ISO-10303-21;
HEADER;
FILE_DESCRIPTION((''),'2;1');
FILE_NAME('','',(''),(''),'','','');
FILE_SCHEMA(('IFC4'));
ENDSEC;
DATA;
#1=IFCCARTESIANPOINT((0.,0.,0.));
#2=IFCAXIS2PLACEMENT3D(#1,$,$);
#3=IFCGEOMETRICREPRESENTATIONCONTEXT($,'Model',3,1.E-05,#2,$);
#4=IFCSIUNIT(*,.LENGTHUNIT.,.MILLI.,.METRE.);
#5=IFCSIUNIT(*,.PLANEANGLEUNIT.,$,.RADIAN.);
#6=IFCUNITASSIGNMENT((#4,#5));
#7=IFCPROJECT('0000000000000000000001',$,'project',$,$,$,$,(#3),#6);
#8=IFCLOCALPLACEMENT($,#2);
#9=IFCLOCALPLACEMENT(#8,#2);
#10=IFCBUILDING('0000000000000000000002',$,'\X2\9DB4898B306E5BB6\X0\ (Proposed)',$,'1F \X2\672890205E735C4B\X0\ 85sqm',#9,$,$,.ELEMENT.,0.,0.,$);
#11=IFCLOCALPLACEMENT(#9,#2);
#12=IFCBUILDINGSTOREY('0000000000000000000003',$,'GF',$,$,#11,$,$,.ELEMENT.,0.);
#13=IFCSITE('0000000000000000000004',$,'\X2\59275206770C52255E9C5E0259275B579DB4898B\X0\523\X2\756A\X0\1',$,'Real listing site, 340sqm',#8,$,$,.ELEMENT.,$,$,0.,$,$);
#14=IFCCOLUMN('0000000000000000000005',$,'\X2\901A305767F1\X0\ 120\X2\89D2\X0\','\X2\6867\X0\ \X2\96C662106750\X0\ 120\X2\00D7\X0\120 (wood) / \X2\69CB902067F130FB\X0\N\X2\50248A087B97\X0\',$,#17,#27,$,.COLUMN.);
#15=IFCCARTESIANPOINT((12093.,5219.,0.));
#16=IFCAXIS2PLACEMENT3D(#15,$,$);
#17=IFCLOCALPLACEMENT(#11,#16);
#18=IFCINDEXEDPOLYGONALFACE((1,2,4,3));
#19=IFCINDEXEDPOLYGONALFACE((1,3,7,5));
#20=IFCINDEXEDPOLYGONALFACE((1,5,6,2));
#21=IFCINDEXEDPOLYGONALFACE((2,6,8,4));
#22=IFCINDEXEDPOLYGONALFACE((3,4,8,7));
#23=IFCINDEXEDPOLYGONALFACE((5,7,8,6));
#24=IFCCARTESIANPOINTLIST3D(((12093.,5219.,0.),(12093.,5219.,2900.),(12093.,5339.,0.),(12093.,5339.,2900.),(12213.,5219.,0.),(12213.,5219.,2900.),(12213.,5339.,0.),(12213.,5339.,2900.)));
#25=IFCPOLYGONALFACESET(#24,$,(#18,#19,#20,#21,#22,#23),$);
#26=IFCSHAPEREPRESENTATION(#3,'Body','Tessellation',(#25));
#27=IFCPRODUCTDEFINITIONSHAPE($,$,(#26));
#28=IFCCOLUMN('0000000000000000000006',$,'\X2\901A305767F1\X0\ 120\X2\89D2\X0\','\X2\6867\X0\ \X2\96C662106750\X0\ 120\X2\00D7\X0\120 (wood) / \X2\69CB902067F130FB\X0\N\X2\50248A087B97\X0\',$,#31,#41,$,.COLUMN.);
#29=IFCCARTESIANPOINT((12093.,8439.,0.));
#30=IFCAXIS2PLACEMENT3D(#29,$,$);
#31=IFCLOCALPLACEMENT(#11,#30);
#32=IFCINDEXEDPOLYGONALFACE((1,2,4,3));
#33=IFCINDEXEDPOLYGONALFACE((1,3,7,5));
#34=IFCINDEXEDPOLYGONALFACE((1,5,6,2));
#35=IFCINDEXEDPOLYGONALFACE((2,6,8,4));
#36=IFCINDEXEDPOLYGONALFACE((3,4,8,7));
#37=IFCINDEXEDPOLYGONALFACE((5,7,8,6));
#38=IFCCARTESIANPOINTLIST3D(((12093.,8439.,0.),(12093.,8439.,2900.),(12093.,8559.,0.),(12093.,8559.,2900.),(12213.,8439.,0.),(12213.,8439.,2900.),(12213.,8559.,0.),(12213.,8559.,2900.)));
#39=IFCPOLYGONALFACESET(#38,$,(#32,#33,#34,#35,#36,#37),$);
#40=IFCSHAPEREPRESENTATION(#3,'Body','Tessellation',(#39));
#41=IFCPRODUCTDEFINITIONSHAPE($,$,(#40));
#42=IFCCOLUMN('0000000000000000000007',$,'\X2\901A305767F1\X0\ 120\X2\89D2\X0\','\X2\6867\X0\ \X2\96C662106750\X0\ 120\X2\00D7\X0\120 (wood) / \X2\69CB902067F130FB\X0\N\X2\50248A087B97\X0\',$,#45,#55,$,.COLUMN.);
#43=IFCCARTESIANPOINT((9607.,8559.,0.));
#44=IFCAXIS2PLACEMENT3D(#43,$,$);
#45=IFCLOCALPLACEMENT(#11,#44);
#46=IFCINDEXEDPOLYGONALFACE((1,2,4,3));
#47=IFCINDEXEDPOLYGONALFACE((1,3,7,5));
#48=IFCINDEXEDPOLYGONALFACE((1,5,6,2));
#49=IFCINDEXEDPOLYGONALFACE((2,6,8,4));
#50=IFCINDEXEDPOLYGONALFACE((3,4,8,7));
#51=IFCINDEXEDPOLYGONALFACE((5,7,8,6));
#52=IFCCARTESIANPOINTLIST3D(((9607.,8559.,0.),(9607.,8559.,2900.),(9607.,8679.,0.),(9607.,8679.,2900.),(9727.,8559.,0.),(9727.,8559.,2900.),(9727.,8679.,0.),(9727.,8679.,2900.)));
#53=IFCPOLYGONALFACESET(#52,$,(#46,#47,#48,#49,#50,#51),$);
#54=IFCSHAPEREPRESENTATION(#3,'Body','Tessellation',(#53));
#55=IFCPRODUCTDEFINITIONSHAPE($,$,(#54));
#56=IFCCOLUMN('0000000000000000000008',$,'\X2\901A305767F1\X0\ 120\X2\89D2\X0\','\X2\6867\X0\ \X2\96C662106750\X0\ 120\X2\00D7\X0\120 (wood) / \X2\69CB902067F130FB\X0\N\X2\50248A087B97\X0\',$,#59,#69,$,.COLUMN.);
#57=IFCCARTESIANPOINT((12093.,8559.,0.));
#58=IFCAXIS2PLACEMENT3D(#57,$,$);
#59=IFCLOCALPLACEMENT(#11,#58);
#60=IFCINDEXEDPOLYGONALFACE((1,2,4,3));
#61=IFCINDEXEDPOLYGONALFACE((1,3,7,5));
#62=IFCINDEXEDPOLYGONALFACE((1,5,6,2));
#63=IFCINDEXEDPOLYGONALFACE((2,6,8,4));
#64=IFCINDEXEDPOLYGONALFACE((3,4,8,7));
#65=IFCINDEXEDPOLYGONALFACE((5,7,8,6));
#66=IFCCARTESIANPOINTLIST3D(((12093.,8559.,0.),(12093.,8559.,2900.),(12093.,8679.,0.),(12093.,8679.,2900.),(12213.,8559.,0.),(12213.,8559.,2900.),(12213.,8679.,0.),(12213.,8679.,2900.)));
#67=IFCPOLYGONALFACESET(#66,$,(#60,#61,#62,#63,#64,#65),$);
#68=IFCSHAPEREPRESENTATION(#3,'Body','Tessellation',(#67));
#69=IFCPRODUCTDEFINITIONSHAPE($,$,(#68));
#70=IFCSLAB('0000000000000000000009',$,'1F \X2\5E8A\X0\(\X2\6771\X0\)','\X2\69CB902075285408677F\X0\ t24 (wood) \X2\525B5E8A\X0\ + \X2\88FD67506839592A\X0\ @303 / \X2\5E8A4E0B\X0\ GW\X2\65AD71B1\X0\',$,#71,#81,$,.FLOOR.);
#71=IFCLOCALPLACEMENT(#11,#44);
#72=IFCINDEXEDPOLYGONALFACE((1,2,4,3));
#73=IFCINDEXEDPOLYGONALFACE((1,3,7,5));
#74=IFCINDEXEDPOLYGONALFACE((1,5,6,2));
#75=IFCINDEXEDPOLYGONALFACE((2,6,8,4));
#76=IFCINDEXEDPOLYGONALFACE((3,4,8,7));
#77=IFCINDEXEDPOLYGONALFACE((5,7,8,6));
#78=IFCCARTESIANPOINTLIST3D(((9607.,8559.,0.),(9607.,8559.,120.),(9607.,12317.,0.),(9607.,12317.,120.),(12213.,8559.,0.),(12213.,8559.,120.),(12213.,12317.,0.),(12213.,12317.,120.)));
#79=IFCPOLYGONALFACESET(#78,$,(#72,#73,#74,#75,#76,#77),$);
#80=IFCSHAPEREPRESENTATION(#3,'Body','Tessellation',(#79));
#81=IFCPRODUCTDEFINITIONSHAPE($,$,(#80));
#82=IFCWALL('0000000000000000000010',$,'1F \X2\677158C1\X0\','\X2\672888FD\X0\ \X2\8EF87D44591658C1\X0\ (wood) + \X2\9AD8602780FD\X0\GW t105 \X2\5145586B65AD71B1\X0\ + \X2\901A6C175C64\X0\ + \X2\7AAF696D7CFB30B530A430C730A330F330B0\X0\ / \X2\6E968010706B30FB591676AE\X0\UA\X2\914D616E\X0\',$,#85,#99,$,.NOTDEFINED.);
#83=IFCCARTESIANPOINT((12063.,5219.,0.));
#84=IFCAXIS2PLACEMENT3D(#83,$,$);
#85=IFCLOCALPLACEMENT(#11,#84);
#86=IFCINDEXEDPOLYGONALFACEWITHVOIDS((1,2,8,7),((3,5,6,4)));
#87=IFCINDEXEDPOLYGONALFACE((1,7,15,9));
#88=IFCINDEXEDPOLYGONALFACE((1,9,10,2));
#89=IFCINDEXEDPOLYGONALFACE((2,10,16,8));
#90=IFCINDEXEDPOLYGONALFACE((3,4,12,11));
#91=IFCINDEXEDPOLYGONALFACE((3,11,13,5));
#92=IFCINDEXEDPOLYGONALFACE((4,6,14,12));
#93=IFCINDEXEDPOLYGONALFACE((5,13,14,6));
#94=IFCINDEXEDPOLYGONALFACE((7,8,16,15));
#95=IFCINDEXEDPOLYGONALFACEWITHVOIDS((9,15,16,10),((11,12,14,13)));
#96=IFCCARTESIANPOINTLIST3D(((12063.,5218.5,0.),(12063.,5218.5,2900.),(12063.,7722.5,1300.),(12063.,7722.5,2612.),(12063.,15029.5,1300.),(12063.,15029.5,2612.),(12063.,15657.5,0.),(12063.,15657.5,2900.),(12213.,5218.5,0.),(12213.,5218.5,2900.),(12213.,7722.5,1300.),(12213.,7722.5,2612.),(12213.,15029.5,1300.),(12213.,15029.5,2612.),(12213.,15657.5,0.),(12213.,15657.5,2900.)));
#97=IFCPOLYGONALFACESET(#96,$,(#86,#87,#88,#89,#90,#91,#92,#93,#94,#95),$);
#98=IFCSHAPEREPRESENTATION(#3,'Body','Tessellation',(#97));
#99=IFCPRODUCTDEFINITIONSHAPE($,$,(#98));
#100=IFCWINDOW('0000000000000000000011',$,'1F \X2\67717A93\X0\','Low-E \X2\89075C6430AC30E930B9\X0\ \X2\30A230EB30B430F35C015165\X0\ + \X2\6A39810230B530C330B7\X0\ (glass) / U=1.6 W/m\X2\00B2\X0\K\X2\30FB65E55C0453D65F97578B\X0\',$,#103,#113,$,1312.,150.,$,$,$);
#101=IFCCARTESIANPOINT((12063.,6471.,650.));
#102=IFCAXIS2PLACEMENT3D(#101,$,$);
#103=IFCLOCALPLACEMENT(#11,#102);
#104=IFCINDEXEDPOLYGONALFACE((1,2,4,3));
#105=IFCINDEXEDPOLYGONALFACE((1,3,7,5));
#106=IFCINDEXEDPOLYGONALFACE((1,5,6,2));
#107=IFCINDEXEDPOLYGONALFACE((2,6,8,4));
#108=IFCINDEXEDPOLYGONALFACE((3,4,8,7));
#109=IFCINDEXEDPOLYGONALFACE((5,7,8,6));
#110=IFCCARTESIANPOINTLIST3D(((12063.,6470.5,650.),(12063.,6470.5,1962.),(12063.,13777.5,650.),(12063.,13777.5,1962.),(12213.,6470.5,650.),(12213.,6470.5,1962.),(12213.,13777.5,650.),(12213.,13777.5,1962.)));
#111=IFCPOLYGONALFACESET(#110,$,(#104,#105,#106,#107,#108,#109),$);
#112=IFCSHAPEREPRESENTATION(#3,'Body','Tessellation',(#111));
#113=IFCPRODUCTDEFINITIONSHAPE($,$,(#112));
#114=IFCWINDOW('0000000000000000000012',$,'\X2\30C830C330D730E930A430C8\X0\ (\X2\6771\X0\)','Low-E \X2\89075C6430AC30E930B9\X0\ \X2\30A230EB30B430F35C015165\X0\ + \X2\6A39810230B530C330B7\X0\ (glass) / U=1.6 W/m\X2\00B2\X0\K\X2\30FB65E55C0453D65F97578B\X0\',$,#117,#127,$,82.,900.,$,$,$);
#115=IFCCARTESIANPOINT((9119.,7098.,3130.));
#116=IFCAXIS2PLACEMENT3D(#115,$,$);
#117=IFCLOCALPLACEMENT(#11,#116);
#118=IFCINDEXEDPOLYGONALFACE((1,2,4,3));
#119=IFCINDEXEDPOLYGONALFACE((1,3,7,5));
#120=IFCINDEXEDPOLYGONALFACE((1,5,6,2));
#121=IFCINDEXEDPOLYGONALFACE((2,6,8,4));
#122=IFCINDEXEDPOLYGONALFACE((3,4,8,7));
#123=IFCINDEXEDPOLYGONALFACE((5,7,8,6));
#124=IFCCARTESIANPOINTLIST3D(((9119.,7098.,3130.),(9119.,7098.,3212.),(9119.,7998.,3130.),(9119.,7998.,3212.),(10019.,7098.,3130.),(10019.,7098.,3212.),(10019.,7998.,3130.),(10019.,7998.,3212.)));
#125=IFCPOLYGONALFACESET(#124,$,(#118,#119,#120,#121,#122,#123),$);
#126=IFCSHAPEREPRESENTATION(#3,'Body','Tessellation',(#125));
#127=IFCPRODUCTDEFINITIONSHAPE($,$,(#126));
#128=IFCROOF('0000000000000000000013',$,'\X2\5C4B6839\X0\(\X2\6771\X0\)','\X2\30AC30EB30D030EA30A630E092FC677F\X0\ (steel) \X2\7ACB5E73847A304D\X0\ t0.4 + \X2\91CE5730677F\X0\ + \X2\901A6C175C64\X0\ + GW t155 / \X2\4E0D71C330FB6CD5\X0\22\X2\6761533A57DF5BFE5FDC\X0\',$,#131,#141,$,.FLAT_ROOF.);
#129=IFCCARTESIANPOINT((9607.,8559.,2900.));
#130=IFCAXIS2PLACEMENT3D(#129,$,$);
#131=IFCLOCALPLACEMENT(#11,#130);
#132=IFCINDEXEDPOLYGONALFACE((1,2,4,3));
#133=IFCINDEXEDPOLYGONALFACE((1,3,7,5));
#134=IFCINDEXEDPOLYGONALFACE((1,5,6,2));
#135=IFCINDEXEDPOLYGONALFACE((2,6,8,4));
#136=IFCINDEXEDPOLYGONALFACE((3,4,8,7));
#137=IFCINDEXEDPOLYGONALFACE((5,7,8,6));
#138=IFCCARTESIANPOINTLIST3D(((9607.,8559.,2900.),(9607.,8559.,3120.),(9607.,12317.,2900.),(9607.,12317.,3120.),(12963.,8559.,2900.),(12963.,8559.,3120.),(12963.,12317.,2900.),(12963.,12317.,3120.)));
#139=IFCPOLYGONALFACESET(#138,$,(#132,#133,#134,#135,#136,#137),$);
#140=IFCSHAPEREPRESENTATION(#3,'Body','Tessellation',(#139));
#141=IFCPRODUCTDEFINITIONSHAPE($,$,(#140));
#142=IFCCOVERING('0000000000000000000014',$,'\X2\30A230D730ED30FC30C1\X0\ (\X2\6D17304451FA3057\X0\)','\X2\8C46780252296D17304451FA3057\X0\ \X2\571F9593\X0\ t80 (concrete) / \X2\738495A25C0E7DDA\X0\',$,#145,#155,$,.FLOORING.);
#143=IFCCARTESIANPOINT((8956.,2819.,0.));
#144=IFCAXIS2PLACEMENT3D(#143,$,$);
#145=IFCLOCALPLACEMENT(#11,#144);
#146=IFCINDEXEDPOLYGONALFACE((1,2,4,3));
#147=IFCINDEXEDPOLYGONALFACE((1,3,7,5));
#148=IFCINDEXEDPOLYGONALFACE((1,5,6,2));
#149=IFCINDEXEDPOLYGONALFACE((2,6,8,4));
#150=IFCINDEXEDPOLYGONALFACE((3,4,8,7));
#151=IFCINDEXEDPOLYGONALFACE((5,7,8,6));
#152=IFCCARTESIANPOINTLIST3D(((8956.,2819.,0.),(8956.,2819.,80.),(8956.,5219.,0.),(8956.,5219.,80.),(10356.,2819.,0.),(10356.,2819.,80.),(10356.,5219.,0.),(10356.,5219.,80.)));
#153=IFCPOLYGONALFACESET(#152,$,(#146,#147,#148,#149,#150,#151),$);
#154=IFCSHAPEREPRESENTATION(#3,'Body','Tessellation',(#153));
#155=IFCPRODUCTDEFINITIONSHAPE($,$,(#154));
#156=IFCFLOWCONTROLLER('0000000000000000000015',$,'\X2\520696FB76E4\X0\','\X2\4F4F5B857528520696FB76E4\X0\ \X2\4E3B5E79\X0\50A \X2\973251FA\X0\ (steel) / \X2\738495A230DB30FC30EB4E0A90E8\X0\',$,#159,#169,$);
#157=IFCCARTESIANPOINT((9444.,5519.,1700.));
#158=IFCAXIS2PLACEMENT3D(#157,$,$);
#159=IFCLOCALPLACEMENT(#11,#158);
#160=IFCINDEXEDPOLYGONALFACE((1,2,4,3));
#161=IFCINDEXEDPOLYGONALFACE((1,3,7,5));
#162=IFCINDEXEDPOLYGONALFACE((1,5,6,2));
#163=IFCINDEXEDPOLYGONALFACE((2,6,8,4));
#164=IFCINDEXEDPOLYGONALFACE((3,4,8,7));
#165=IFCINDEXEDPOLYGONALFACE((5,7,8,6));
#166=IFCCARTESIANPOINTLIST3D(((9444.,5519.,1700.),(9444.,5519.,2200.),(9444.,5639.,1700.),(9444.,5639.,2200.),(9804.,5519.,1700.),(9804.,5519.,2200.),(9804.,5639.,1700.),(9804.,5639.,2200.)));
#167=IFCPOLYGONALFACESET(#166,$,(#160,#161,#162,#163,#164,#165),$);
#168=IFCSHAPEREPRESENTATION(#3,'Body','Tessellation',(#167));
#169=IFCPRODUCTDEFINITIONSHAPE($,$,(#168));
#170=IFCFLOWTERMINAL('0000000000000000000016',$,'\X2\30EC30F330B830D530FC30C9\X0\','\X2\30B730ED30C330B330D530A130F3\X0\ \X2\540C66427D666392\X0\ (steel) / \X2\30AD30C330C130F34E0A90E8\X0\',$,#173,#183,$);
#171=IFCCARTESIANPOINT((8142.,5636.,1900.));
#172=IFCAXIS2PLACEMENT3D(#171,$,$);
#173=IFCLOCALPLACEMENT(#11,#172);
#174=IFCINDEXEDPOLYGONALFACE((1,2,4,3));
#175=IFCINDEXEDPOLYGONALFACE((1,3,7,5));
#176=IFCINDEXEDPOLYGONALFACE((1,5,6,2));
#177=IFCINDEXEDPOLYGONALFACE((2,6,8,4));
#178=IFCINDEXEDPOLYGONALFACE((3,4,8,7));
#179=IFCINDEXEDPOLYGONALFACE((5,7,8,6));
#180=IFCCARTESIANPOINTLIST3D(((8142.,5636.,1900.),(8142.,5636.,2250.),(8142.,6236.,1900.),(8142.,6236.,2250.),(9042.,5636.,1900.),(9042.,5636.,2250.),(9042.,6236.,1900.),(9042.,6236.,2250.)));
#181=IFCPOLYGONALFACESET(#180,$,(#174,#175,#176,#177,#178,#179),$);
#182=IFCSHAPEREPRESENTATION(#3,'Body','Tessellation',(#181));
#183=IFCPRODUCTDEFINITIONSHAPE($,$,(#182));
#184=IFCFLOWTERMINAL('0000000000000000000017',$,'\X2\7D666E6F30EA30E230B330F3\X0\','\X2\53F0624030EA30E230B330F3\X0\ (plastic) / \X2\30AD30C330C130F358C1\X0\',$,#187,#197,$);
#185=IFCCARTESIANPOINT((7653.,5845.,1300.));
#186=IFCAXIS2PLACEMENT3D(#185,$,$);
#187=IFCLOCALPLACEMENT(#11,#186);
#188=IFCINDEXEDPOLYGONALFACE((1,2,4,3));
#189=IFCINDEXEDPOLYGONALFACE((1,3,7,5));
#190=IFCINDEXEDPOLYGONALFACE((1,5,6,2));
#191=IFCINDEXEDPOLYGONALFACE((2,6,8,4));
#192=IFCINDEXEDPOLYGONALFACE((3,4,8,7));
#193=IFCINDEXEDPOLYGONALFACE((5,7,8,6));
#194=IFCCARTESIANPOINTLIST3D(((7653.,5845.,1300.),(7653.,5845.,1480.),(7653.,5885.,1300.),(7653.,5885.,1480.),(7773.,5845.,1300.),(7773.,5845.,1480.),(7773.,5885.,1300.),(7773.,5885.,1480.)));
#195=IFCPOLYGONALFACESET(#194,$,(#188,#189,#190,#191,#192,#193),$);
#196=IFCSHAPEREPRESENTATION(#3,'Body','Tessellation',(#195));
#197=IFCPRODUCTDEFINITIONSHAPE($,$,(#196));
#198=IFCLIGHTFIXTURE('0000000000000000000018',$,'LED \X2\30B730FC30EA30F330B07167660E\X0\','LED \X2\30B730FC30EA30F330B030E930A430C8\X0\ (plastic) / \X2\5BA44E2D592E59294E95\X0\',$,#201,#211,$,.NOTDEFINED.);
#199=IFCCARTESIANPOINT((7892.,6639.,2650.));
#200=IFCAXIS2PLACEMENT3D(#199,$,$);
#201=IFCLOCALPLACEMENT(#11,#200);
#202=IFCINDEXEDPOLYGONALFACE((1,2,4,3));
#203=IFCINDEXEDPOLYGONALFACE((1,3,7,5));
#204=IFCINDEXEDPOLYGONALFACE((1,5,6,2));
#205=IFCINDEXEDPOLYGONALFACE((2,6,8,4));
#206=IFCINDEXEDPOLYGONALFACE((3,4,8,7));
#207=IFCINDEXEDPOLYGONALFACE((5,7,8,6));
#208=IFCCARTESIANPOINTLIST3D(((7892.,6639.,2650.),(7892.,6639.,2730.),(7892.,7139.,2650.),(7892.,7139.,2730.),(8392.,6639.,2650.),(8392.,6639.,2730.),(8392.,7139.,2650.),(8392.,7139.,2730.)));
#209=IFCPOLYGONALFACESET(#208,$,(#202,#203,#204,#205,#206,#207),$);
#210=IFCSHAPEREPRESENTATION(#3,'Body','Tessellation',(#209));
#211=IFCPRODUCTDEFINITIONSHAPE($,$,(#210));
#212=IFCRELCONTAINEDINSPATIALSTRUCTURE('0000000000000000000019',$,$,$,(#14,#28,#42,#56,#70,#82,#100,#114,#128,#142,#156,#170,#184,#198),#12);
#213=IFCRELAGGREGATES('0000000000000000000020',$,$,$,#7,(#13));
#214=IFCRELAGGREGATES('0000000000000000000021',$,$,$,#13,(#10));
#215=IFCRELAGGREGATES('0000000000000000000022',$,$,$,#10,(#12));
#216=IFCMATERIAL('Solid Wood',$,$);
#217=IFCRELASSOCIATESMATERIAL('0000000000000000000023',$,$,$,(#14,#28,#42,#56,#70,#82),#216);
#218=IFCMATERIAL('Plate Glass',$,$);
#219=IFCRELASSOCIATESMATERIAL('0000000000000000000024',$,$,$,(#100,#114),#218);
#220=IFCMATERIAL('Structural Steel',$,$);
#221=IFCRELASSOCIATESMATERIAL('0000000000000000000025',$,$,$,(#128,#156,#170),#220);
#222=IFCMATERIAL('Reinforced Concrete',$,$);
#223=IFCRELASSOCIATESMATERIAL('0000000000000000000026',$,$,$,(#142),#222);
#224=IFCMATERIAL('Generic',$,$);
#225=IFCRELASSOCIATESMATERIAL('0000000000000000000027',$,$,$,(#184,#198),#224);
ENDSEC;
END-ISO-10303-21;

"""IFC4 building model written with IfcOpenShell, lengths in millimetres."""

from ifc_helpers import new_model, si_unit, frame, frame_2d, origin, place, context, project, spatial, rectangle, extrude, material, element, fill, save


model = new_model("IFC4")

# Units and contexts
model_context = context("Model", 3, precision=1e-05, world=origin())
ifc_project = project(units=[si_unit("LENGTHUNIT", "METRE", prefix="MILLI"), si_unit("PLANEANGLEUNIT", "RADIAN")], contexts=[model_context])

# Site, building, storey
site_placement = place(None, origin())
site = spatial("IfcSite", under=ifc_project, at=site_placement, Name="大分県別府市大字鶴見523番1", ObjectType="Real listing site, 340sqm", CompositionType="ELEMENT", RefElevation=0.0)
building_placement = place(site_placement, origin())
building = spatial("IfcBuilding", under=site, at=building_placement, Name="鶴見の家 (Proposed)", ObjectType="1F 木造平屋 85sqm", CompositionType="ELEMENT", ElevationOfRefHeight=0.0, ElevationOfTerrain=0.0)
storey_placement = place(building_placement, origin())
storey = spatial("IfcBuildingStorey", under=building, at=storey_placement, Name="GF", CompositionType="ELEMENT", Elevation=0.0)

# Columns
ifc_material_1 = material(Name="Solid Wood")
column_1_placement = place(storey_placement, frame((12093.0, 5219.0, 0.0)))
element("IfcColumn", 1, at=column_1_placement, inside=storey, material=ifc_material_1, Name="通し柱 120角", Description="桧 集成材 120×120 (wood) / 構造柱・N値計算", PredefinedType="COLUMN", context=model_context, shape_type="SweptSolid", body=[
    extrude(rectangle(XDim=120.0, YDim=120.0, at=frame_2d((60.0, 60.0))), frame((12093.0, 5219.0, 0.0)), (0.0, 0.0, 1.0), 2900.0),
])
column_2_placement = place(storey_placement, frame((12093.0, 8439.0, 0.0)))
element("IfcColumn", 2, at=column_2_placement, inside=storey, material=ifc_material_1, Name="通し柱 120角", Description="桧 集成材 120×120 (wood) / 構造柱・N値計算", PredefinedType="COLUMN", context=model_context, shape_type="SweptSolid", body=[
    extrude(rectangle(XDim=120.0, YDim=120.0, at=frame_2d((60.0, 60.0))), frame((12093.0, 8439.0, 0.0)), (0.0, 0.0, 1.0), 2900.0),
])
column_3_placement = place(storey_placement, frame((9607.0, 8559.0, 0.0)))
element("IfcColumn", 3, at=column_3_placement, inside=storey, material=ifc_material_1, Name="通し柱 120角", Description="桧 集成材 120×120 (wood) / 構造柱・N値計算", PredefinedType="COLUMN", context=model_context, shape_type="SweptSolid", body=[
    extrude(rectangle(XDim=120.0, YDim=120.0, at=frame_2d((60.0, 60.0))), frame((9607.0, 8559.0, 0.0)), (0.0, 0.0, 1.0), 2900.0),
])
column_4_placement = place(storey_placement, frame((12093.0, 8559.0, 0.0)))
element("IfcColumn", 4, at=column_4_placement, inside=storey, material=ifc_material_1, Name="通し柱 120角", Description="桧 集成材 120×120 (wood) / 構造柱・N値計算", PredefinedType="COLUMN", context=model_context, shape_type="SweptSolid", body=[
    extrude(rectangle(XDim=120.0, YDim=120.0, at=frame_2d((60.0, 60.0))), frame((12093.0, 8559.0, 0.0)), (0.0, 0.0, 1.0), 2900.0),
])

# Slab
slab_placement = place(storey_placement, frame((9607.0, 8559.0, 0.0)))
element("IfcSlab", 5, at=slab_placement, inside=storey, material=ifc_material_1, Name="1F 床(東)", Description="構造用合板 t24 (wood) 剛床 + 製材根太 @303 / 床下 GW断熱", PredefinedType="FLOOR", context=model_context, shape_type="SweptSolid", body=[
    extrude(rectangle(XDim=2606.0, YDim=3758.0, at=frame_2d((1303.0, 1879.0))), frame((9607.0, 8559.0, 0.0)), (0.0, 0.0, 1.0), 120.0),
])

# Wall, opening, window
wall_1_placement = place(storey_placement, frame((12063.0, 5219.0, 0.0)))
wall_1 = element("IfcWall", 6, at=wall_1_placement, inside=storey, material=ifc_material_1, Name="1F 東壁", Description="木製 軸組外壁 (wood) + 高性能GW t105 充填断熱 + 通気層 + 窯業系サイディング / 準耐火・外皮UA配慮", PredefinedType="NOTDEFINED", context=model_context, shape_type="SweptSolid", body=[
    extrude(rectangle(XDim=150.0, YDim=10439.0, at=frame_2d((75.0, 5219.0))), frame((12063.0, 5219.0, 0.0)), (0.0, 0.0, 1.0), 2900.0),
])
opening_placement = place(storey_placement, frame((12063.0, 6471.0, 650.0)))
opening = element("IfcOpeningElement", 7, at=opening_placement, cuts=wall_1, PredefinedType="NOTDEFINED", context=model_context, shape_type="SweptSolid", body=[
    extrude(rectangle(XDim=150.0, YDim=7307.0, at=frame_2d((75.0, 3653.0))), frame((12063.0, 6471.0, 650.0)), (0.0, 0.0, 1.0), 1312.0),
])
ifc_material_2 = material(Name="Plate Glass")
window_1_placement = place(storey_placement, frame((12063.0, 6471.0, 650.0)))
window_1 = element("IfcWindow", 8, at=window_1_placement, inside=storey, material=ifc_material_2, Name="1F 東窓", Description="Low-E 複層ガラス アルゴン封入 + 樹脂サッシ (glass) / U=1.6 W/m²K・日射取得型", OverallHeight=1312.0, OverallWidth=150.0, context=model_context, shape_type="SweptSolid", body=[
    extrude(rectangle(XDim=150.0, YDim=7307.0, at=frame_2d((75.0, 3653.0))), frame((12063.0, 6471.0, 650.0)), (0.0, 0.0, 1.0), 1312.0),
])
fill(opening, window_1)

# Window
window_2_placement = place(storey_placement, frame((9119.0, 7098.0, 3130.0)))
element("IfcWindow", 9, at=window_2_placement, inside=storey, material=ifc_material_2, Name="トップライト (東)", Description="Low-E 複層ガラス アルゴン封入 + 樹脂サッシ (glass) / U=1.6 W/m²K・日射取得型", OverallHeight=82.0, OverallWidth=900.0, context=model_context, shape_type="SweptSolid", body=[
    extrude(rectangle(XDim=900.0, YDim=900.0, at=frame_2d((450.0, 450.0))), frame((9119.0, 7098.0, 3130.0)), (0.0, 0.0, 1.0), 82.0),
])

# Roof
ifc_material_3 = material(Name="Structural Steel")
roof_placement = place(storey_placement, frame((9607.0, 8559.0, 2900.0)))
element("IfcRoof", 10, at=roof_placement, inside=storey, material=ifc_material_3, Name="屋根(東)", Description="ガルバリウム鋼板 (steel) 立平葺き t0.4 + 野地板 + 通気層 + GW t155 / 不燃・法22条区域対応", PredefinedType="FLAT_ROOF", context=model_context, shape_type="SweptSolid", body=[
    extrude(rectangle(XDim=3356.0, YDim=3758.0, at=frame_2d((1678.0, 1879.0))), frame((9607.0, 8559.0, 2900.0)), (0.0, 0.0, 1.0), 220.0),
])

# Covering
ifc_material_4 = material(Name="Reinforced Concrete")
covering_placement = place(storey_placement, frame((8956.0, 2819.0, 0.0)))
element("IfcCovering", 11, at=covering_placement, inside=storey, material=ifc_material_4, Name="アプローチ (洗い出し)", Description="豆砂利洗い出し 土間 t80 (concrete) / 玄関導線", PredefinedType="FLOORING", context=model_context, shape_type="SweptSolid", body=[
    extrude(rectangle(XDim=1400.0, YDim=2400.0, at=frame_2d((700.0, 1200.0))), frame((8956.0, 2819.0, 0.0)), (0.0, 0.0, 1.0), 80.0),
])

# Flow controller
flow_controller_placement = place(storey_placement, frame((9444.0, 5519.0, 1700.0)))
element("IfcFlowController", 12, at=flow_controller_placement, inside=storey, material=ifc_material_3, Name="分電盤", Description="住宅用分電盤 主幹50A 露出 (steel) / 玄関ホール上部", context=model_context, shape_type="SweptSolid", body=[
    extrude(rectangle(XDim=360.0, YDim=120.0, at=frame_2d((180.0, 60.0))), frame((9444.0, 5519.0, 1700.0)), (0.0, 0.0, 1.0), 500.0),
])

# Flow terminals
flow_terminal_1_placement = place(storey_placement, frame((8142.0, 5636.0, 1900.0)))
element("IfcFlowTerminal", 13, at=flow_terminal_1_placement, inside=storey, material=ifc_material_3, Name="レンジフード", Description="シロッコファン 同時給排 (steel) / キッチン上部", context=model_context, shape_type="SweptSolid", body=[
    extrude(rectangle(XDim=900.0, YDim=600.0, at=frame_2d((450.0, 300.0))), frame((8142.0, 5636.0, 1900.0)), (0.0, 0.0, 1.0), 350.0),
])
ifc_material_5 = material(Name="Generic")
flow_terminal_2_placement = place(storey_placement, frame((7653.0, 5845.0, 1300.0)))
element("IfcFlowTerminal", 14, at=flow_terminal_2_placement, inside=storey, material=ifc_material_5, Name="給湯リモコン", Description="台所リモコン (plastic) / キッチン壁", context=model_context, shape_type="SweptSolid", body=[
    extrude(rectangle(XDim=120.0, YDim=40.0, at=frame_2d((60.0, 20.0))), frame((7653.0, 5845.0, 1300.0)), (0.0, 0.0, 1.0), 180.0),
])

# Light fixture
light_fixture_placement = place(storey_placement, frame((7892.0, 6639.0, 2650.0)))
element("IfcLightFixture", 15, at=light_fixture_placement, inside=storey, material=ifc_material_5, Name="LED シーリング照明", Description="LED シーリングライト (plastic) / 室中央天井", PredefinedType="NOTDEFINED", context=model_context, shape_type="SweptSolid", body=[
    extrude(rectangle(XDim=500.0, YDim=500.0, at=frame_2d((250.0, 250.0))), frame((7892.0, 6639.0, 2650.0)), (0.0, 0.0, 1.0), 80.0),
])

save(model, "model.ifc")
